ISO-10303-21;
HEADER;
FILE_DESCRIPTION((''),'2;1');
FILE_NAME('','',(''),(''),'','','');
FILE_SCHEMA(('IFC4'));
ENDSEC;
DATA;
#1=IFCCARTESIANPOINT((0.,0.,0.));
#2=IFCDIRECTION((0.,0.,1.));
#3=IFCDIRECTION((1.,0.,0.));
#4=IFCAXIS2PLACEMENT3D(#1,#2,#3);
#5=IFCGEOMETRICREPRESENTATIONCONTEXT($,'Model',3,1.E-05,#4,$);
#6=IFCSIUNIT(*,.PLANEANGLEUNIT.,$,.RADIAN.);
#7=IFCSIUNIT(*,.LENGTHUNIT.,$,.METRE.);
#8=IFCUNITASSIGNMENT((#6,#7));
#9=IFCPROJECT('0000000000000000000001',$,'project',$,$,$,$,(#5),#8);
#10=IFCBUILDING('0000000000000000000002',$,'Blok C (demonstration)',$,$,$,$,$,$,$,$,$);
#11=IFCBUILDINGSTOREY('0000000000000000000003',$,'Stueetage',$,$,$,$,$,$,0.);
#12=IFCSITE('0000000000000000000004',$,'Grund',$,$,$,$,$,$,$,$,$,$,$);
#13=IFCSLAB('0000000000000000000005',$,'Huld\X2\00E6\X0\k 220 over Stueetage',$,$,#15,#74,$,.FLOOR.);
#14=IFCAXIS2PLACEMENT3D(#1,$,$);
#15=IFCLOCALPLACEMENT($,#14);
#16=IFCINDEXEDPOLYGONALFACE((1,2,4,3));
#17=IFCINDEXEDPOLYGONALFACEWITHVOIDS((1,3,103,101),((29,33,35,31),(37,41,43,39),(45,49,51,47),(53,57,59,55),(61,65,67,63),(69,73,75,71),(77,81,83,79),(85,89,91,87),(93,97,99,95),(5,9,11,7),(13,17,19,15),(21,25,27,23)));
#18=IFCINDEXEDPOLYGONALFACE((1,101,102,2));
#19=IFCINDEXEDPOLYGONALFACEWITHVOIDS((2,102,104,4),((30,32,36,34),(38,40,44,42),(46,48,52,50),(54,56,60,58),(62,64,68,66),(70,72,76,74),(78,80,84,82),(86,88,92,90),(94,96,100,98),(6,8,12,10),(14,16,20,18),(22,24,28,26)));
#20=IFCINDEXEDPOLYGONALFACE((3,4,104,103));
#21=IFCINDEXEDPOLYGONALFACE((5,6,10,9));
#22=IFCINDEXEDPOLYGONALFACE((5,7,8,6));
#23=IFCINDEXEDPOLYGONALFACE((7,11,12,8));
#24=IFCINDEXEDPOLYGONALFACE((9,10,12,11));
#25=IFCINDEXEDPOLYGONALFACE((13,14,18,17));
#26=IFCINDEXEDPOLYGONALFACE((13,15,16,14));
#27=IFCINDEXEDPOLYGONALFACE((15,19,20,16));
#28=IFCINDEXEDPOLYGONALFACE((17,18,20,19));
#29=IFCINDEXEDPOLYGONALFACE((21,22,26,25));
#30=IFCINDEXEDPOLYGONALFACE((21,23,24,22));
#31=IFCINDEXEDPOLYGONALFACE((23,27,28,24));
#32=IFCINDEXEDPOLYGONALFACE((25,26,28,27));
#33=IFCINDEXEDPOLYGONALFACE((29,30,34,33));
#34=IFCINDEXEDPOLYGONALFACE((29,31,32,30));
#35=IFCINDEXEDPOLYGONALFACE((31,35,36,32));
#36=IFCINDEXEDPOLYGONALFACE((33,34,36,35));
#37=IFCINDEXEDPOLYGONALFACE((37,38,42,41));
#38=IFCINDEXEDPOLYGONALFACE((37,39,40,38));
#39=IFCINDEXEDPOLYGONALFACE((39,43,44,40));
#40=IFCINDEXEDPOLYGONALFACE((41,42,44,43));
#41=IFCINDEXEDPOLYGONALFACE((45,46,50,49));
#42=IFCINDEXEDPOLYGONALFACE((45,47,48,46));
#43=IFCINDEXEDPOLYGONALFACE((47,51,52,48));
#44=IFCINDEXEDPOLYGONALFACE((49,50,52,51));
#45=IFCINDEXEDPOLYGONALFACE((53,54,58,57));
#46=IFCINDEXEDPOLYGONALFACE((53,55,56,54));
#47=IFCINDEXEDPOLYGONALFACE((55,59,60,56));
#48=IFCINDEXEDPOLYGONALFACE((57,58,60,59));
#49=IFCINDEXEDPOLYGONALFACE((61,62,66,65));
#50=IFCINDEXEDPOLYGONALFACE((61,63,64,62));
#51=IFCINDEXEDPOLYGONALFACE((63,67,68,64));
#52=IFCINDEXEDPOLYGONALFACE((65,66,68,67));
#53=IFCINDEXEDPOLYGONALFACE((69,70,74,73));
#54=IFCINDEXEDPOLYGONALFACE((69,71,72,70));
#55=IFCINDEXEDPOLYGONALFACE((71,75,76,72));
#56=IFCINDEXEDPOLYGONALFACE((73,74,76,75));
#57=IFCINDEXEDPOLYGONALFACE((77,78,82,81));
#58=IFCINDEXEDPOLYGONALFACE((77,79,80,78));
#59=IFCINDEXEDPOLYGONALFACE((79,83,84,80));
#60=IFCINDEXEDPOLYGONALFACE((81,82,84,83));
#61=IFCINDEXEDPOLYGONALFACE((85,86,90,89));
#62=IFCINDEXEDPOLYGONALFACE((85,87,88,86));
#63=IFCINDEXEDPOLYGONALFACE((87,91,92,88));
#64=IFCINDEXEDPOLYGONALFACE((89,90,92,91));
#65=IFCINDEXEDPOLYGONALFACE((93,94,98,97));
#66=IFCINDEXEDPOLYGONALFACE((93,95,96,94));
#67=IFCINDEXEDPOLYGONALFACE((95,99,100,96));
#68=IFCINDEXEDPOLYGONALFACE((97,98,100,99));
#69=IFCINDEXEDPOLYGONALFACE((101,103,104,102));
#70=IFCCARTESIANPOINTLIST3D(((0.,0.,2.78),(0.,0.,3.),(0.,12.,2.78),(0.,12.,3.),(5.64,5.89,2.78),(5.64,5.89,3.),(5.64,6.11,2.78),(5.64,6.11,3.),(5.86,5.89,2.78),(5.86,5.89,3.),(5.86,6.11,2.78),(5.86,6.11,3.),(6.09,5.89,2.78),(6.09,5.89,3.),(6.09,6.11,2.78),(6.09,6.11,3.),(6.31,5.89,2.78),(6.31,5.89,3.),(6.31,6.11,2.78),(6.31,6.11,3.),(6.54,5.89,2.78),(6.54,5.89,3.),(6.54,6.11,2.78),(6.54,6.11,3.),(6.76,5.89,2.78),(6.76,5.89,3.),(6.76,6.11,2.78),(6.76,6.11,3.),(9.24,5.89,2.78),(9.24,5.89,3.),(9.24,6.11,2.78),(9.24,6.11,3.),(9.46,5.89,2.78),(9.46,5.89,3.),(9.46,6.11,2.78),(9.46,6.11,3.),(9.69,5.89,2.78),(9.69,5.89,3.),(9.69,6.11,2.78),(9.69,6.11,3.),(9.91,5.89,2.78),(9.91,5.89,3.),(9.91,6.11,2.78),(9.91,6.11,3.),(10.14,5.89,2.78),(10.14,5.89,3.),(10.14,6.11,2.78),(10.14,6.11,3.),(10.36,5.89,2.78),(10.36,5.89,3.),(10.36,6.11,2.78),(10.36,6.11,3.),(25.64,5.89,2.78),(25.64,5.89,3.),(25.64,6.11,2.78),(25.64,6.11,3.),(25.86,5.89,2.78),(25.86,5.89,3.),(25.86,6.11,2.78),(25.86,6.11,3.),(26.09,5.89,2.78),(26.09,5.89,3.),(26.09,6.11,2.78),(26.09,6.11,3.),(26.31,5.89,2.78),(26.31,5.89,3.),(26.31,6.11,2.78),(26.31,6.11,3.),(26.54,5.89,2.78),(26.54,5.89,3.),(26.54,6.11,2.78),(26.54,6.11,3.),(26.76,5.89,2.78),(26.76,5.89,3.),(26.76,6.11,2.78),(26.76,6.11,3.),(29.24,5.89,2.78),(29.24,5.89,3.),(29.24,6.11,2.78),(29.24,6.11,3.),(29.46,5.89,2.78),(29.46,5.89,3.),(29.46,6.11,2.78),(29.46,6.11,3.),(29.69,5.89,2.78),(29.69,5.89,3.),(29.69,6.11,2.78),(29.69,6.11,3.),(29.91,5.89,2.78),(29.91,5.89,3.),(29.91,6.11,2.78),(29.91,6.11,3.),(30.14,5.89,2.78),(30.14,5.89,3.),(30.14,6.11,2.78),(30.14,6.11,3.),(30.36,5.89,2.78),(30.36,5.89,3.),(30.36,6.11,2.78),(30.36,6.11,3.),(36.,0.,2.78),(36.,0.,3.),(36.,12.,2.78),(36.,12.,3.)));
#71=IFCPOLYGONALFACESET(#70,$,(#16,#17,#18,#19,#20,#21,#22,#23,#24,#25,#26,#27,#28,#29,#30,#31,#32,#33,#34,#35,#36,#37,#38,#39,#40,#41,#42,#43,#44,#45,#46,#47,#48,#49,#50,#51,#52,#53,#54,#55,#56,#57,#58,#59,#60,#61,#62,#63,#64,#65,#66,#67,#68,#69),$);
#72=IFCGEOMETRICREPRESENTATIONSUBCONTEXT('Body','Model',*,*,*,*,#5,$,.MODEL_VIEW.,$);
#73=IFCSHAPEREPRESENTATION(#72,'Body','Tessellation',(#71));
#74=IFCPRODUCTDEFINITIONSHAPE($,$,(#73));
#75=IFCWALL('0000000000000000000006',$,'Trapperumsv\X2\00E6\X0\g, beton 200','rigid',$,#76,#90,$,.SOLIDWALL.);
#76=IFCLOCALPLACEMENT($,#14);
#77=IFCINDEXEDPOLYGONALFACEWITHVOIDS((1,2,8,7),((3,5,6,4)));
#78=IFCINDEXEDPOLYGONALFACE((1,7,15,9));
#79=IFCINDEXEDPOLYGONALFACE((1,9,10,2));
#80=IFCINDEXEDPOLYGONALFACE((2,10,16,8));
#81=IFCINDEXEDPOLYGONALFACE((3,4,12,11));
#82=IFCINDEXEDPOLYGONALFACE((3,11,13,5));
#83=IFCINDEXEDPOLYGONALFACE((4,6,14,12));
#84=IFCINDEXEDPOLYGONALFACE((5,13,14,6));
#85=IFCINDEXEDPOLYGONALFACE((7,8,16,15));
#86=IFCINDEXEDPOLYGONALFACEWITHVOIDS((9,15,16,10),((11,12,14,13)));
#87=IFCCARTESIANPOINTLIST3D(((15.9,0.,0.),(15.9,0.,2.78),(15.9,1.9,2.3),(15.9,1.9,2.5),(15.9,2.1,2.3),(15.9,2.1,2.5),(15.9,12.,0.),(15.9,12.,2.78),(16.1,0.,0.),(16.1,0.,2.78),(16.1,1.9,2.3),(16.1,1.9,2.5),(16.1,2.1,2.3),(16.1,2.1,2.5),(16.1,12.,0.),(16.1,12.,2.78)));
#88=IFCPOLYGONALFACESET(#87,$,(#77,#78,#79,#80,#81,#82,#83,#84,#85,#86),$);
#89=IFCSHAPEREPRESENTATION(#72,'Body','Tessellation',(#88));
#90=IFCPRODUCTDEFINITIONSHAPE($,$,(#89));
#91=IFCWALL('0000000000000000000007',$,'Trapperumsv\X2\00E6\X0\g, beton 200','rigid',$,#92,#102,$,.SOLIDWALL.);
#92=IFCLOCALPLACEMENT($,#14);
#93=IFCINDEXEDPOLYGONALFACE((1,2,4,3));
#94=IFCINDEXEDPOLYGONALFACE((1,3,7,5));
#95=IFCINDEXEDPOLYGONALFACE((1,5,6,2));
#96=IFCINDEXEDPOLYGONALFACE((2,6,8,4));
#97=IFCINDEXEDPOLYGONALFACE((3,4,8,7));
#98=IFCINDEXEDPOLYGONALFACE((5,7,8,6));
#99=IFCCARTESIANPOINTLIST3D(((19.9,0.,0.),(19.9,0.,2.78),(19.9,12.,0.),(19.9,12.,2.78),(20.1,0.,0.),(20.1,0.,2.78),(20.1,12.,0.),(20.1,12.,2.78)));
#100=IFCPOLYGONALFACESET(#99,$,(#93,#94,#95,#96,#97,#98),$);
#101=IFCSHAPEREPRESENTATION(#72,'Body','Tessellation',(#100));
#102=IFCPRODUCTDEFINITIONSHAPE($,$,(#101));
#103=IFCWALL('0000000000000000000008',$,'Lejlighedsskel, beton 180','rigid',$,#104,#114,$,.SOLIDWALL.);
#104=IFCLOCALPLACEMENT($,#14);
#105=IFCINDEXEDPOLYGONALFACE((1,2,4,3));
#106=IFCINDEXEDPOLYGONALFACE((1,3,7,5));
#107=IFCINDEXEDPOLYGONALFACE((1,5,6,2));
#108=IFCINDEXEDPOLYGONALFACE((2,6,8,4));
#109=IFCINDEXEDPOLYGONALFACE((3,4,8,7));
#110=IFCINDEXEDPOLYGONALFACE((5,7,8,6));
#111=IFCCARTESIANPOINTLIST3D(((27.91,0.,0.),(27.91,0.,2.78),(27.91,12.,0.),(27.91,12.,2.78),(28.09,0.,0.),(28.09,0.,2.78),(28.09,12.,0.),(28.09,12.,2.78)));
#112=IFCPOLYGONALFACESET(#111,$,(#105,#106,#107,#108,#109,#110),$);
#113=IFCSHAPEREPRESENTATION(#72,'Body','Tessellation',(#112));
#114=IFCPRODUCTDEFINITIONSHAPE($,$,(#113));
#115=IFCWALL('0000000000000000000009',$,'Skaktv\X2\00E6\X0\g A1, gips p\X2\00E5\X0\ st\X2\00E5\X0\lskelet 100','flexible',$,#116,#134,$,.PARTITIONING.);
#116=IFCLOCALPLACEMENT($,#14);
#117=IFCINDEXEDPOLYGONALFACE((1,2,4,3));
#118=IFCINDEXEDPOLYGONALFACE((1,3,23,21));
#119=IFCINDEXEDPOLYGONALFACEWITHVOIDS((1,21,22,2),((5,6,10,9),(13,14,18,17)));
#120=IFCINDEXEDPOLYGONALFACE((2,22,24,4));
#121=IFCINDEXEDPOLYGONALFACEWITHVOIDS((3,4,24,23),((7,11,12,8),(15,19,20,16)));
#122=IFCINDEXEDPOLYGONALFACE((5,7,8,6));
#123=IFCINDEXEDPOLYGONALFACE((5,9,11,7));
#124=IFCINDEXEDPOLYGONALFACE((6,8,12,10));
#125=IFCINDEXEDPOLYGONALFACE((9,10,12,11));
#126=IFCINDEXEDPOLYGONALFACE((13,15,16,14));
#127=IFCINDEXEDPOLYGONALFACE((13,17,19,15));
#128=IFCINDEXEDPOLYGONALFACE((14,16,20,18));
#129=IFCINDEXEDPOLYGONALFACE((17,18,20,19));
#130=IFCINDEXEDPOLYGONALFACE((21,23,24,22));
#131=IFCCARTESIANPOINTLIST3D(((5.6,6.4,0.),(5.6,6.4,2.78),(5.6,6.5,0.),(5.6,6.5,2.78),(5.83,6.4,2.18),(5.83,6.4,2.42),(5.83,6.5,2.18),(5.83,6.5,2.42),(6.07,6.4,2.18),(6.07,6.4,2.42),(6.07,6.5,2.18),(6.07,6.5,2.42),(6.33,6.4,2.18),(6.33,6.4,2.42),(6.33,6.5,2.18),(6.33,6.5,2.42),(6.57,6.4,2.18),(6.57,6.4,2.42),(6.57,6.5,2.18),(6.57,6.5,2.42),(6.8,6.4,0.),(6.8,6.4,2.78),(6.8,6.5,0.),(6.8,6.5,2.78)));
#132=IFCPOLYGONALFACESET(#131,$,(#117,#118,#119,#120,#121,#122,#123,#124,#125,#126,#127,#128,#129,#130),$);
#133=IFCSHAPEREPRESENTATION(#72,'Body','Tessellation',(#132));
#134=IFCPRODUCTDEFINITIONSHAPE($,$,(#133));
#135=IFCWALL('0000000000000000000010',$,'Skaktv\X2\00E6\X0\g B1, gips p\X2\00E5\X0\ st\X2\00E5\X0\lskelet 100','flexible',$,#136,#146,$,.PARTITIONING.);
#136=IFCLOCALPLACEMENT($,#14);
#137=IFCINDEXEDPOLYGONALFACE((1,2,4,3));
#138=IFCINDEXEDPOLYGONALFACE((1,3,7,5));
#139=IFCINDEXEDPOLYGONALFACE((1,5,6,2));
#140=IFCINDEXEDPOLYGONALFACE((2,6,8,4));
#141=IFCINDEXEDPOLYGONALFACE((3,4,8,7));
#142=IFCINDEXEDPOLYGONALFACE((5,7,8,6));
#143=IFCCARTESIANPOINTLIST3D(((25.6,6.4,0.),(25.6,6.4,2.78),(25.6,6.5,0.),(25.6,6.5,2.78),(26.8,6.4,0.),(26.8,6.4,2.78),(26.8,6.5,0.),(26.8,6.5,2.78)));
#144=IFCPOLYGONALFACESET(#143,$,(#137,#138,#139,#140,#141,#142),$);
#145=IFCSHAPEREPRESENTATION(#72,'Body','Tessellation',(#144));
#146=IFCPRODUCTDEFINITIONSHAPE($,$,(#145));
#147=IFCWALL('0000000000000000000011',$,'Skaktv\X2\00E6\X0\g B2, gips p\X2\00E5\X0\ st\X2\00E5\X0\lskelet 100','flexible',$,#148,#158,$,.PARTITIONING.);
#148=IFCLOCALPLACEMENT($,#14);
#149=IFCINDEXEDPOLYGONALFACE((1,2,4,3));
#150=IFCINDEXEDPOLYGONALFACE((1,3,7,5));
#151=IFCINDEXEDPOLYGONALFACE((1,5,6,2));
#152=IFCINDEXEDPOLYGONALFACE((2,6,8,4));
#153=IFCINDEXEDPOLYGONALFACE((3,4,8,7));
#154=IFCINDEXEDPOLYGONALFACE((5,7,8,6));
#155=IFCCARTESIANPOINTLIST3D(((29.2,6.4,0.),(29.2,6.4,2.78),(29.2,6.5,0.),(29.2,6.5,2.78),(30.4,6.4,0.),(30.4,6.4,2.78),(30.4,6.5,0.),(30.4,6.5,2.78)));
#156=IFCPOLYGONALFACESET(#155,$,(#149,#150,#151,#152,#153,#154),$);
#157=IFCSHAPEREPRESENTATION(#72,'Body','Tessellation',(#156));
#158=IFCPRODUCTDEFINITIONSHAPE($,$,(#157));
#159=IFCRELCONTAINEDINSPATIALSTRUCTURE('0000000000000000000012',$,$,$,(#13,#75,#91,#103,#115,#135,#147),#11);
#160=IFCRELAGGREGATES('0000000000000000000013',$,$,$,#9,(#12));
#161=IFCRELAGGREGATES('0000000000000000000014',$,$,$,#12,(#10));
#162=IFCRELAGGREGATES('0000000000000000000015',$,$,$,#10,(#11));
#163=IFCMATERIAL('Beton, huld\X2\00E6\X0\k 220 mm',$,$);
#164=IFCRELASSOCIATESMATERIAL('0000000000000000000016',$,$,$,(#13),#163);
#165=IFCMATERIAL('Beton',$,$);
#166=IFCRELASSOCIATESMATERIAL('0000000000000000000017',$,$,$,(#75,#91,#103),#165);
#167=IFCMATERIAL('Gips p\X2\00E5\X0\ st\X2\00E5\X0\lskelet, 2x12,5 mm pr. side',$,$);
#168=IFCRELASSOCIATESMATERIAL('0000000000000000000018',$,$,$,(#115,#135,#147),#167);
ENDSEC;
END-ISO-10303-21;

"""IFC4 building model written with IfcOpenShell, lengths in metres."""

from ifc_helpers import new_model, si_unit, frame, origin, origin_with_axes, place, context, subcontext, project, spatial, polyline, outline, extrude, material, element, save


model = new_model("IFC4")

# Units and contexts
model_context = context("Model", 3, precision=1e-05, world=origin_with_axes())
body_context = subcontext(model_context, "Body", "Model", "MODEL_VIEW")
ifc_project = project(units=[si_unit("PLANEANGLEUNIT", "RADIAN"), si_unit("LENGTHUNIT", "METRE")], contexts=[model_context])

# Site, building, storey
site = spatial("IfcSite", under=ifc_project, Name="Grund")
building = spatial("IfcBuilding", under=site, Name="Blok C (demonstration)")
storey = spatial("IfcBuildingStorey", under=building, Name="Stueetage", Elevation=0.0)

# Slab, openings
ifc_material_1 = material(Name="Beton, huldæk 220 mm")
slab_placement = place(None, origin_with_axes())
slab = element("IfcSlab", 1, at=slab_placement, inside=storey, material=ifc_material_1, Name="Huldæk 220 over Stueetage", PredefinedType="FLOOR", context=body_context, shape_type="SweptSolid", body=[
    extrude(outline(polyline([(0.0, 0.0), (36.0, 0.0), (36.0, 12.0), (0.0, 12.0), (0.0, 0.0)])), frame((0.0, 0.0, 2.78)), (0.0, 0.0, 1.0), 0.22),
])
opening_1_placement = place(slab_placement, origin_with_axes())
element("IfcOpeningElement", 2, at=opening_1_placement, cuts=slab, PredefinedType="OPENING", context=body_context, shape_type="SweptSolid", body=[
    extrude(outline(polyline([(5.64, 5.89), (5.86, 5.89), (5.86, 6.11), (5.64, 6.11), (5.64, 5.89)])), frame((0.0, 0.0, 2.77)), (0.0, 0.0, 1.0), 0.24),
])
opening_2_placement = place(slab_placement, origin_with_axes())
element("IfcOpeningElement", 3, at=opening_2_placement, cuts=slab, PredefinedType="OPENING", context=body_context, shape_type="SweptSolid", body=[
    extrude(outline(polyline([(6.09, 5.89), (6.31, 5.89), (6.31, 6.11), (6.09, 6.11), (6.09, 5.89)])), frame((0.0, 0.0, 2.77)), (0.0, 0.0, 1.0), 0.24),
])
opening_3_placement = place(slab_placement, origin_with_axes())
element("IfcOpeningElement", 4, at=opening_3_placement, cuts=slab, PredefinedType="OPENING", context=body_context, shape_type="SweptSolid", body=[
    extrude(outline(polyline([(6.54, 5.89), (6.76, 5.89), (6.76, 6.11), (6.54, 6.11), (6.54, 5.89)])), frame((0.0, 0.0, 2.77)), (0.0, 0.0, 1.0), 0.24),
])
opening_4_placement = place(slab_placement, origin_with_axes())
element("IfcOpeningElement", 5, at=opening_4_placement, cuts=slab, PredefinedType="OPENING", context=body_context, shape_type="SweptSolid", body=[
    extrude(outline(polyline([(9.24, 5.89), (9.46, 5.89), (9.46, 6.11), (9.24, 6.11), (9.24, 5.89)])), frame((0.0, 0.0, 2.77)), (0.0, 0.0, 1.0), 0.24),
])
opening_5_placement = place(slab_placement, origin_with_axes())
element("IfcOpeningElement", 6, at=opening_5_placement, cuts=slab, PredefinedType="OPENING", context=body_context, shape_type="SweptSolid", body=[
    extrude(outline(polyline([(9.69, 5.89), (9.91, 5.89), (9.91, 6.11), (9.69, 6.11), (9.69, 5.89)])), frame((0.0, 0.0, 2.77)), (0.0, 0.0, 1.0), 0.24),
])
opening_6_placement = place(slab_placement, origin_with_axes())
element("IfcOpeningElement", 7, at=opening_6_placement, cuts=slab, PredefinedType="OPENING", context=body_context, shape_type="SweptSolid", body=[
    extrude(outline(polyline([(10.14, 5.89), (10.36, 5.89), (10.36, 6.11), (10.14, 6.11), (10.14, 5.89)])), frame((0.0, 0.0, 2.77)), (0.0, 0.0, 1.0), 0.24),
])
opening_7_placement = place(slab_placement, origin_with_axes())
element("IfcOpeningElement", 8, at=opening_7_placement, cuts=slab, PredefinedType="OPENING", context=body_context, shape_type="SweptSolid", body=[
    extrude(outline(polyline([(25.64, 5.89), (25.86, 5.89), (25.86, 6.11), (25.64, 6.11), (25.64, 5.89)])), frame((0.0, 0.0, 2.77)), (0.0, 0.0, 1.0), 0.24),
])
opening_8_placement = place(slab_placement, origin_with_axes())
element("IfcOpeningElement", 9, at=opening_8_placement, cuts=slab, PredefinedType="OPENING", context=body_context, shape_type="SweptSolid", body=[
    extrude(outline(polyline([(26.09, 5.89), (26.31, 5.89), (26.31, 6.11), (26.09, 6.11), (26.09, 5.89)])), frame((0.0, 0.0, 2.77)), (0.0, 0.0, 1.0), 0.24),
])
opening_9_placement = place(slab_placement, origin_with_axes())
element("IfcOpeningElement", 10, at=opening_9_placement, cuts=slab, PredefinedType="OPENING", context=body_context, shape_type="SweptSolid", body=[
    extrude(outline(polyline([(26.54, 5.89), (26.76, 5.89), (26.76, 6.11), (26.54, 6.11), (26.54, 5.89)])), frame((0.0, 0.0, 2.77)), (0.0, 0.0, 1.0), 0.24),
])
opening_10_placement = place(slab_placement, origin_with_axes())
element("IfcOpeningElement", 11, at=opening_10_placement, cuts=slab, PredefinedType="OPENING", context=body_context, shape_type="SweptSolid", body=[
    extrude(outline(polyline([(29.24, 5.89), (29.46, 5.89), (29.46, 6.11), (29.24, 6.11), (29.24, 5.89)])), frame((0.0, 0.0, 2.77)), (0.0, 0.0, 1.0), 0.24),
])
opening_11_placement = place(slab_placement, origin_with_axes())
element("IfcOpeningElement", 12, at=opening_11_placement, cuts=slab, PredefinedType="OPENING", context=body_context, shape_type="SweptSolid", body=[
    extrude(outline(polyline([(29.69, 5.89), (29.91, 5.89), (29.91, 6.11), (29.69, 6.11), (29.69, 5.89)])), frame((0.0, 0.0, 2.77)), (0.0, 0.0, 1.0), 0.24),
])
opening_12_placement = place(slab_placement, origin_with_axes())
element("IfcOpeningElement", 13, at=opening_12_placement, cuts=slab, PredefinedType="OPENING", context=body_context, shape_type="SweptSolid", body=[
    extrude(outline(polyline([(30.14, 5.89), (30.36, 5.89), (30.36, 6.11), (30.14, 6.11), (30.14, 5.89)])), frame((0.0, 0.0, 2.77)), (0.0, 0.0, 1.0), 0.24),
])

# Wall, opening
ifc_material_2 = material(Name="Beton")
wall_1_placement = place(None, origin_with_axes())
wall_1 = element("IfcWall", 14, at=wall_1_placement, inside=storey, material=ifc_material_2, Name="Trapperumsvæg, beton 200", Description="rigid", PredefinedType="SOLIDWALL", context=body_context, shape_type="SweptSolid", body=[
    extrude(outline(polyline([(15.9, 0.0), (16.1, 0.0), (16.1, 12.0), (15.9, 12.0), (15.9, 0.0)])), origin(), (0.0, 0.0, 1.0), 2.78),
])
opening_13_placement = place(wall_1_placement, origin_with_axes())
element("IfcOpeningElement", 15, at=opening_13_placement, cuts=wall_1, PredefinedType="OPENING", context=body_context, shape_type="SweptSolid", body=[
    extrude(outline(polyline([(15.88, 1.9), (16.12, 1.9), (16.12, 2.1), (15.88, 2.1), (15.88, 1.9)])), frame((0.0, 0.0, 2.3)), (0.0, 0.0, 1.0), 0.2),
])

# Wall
wall_2_placement = place(None, origin_with_axes())
element("IfcWall", 16, at=wall_2_placement, inside=storey, material=ifc_material_2, Name="Trapperumsvæg, beton 200", Description="rigid", PredefinedType="SOLIDWALL", context=body_context, shape_type="SweptSolid", body=[
    extrude(outline(polyline([(19.9, 0.0), (20.1, 0.0), (20.1, 12.0), (19.9, 12.0), (19.9, 0.0)])), origin(), (0.0, 0.0, 1.0), 2.78),
])

# Wall
wall_3_placement = place(None, origin_with_axes())
element("IfcWall", 17, at=wall_3_placement, inside=storey, material=ifc_material_2, Name="Lejlighedsskel, beton 180", Description="rigid", PredefinedType="SOLIDWALL", context=body_context, shape_type="SweptSolid", body=[
    extrude(outline(polyline([(27.91, 0.0), (28.09, 0.0), (28.09, 12.0), (27.91, 12.0), (27.91, 0.0)])), origin(), (0.0, 0.0, 1.0), 2.78),
])

# Wall, openings
ifc_material_3 = material(Name="Gips på stålskelet, 2x12,5 mm pr. side")
wall_4_placement = place(None, origin_with_axes())
wall_4 = element("IfcWall", 18, at=wall_4_placement, inside=storey, material=ifc_material_3, Name="Skaktvæg A1, gips på stålskelet 100", Description="flexible", PredefinedType="PARTITIONING", context=body_context, shape_type="SweptSolid", body=[
    extrude(outline(polyline([(5.6, 6.4), (6.8, 6.4), (6.8, 6.5), (5.6, 6.5), (5.6, 6.4)])), origin(), (0.0, 0.0, 1.0), 2.78),
])
opening_14_placement = place(wall_4_placement, origin_with_axes())
element("IfcOpeningElement", 19, at=opening_14_placement, cuts=wall_4, PredefinedType="OPENING", context=body_context, shape_type="SweptSolid", body=[
    extrude(outline(polyline([(5.83, 6.33), (6.07, 6.33), (6.07, 6.57), (5.83, 6.57), (5.83, 6.33)])), frame((0.0, 0.0, 2.18)), (0.0, 0.0, 1.0), 0.24),
])
opening_15_placement = place(wall_4_placement, origin_with_axes())
element("IfcOpeningElement", 20, at=opening_15_placement, cuts=wall_4, PredefinedType="OPENING", context=body_context, shape_type="SweptSolid", body=[
    extrude(outline(polyline([(6.33, 6.33), (6.57, 6.33), (6.57, 6.57), (6.33, 6.57), (6.33, 6.33)])), frame((0.0, 0.0, 2.18)), (0.0, 0.0, 1.0), 0.24),
])

# Walls
wall_5_placement = place(None, origin_with_axes())
element("IfcWall", 21, at=wall_5_placement, inside=storey, material=ifc_material_3, Name="Skaktvæg B1, gips på stålskelet 100", Description="flexible", PredefinedType="PARTITIONING", context=body_context, shape_type="SweptSolid", body=[
    extrude(outline(polyline([(25.6, 6.4), (26.8, 6.4), (26.8, 6.5), (25.6, 6.5), (25.6, 6.4)])), origin(), (0.0, 0.0, 1.0), 2.78),
])
wall_6_placement = place(None, origin_with_axes())
element("IfcWall", 22, at=wall_6_placement, inside=storey, material=ifc_material_3, Name="Skaktvæg B2, gips på stålskelet 100", Description="flexible", PredefinedType="PARTITIONING", context=body_context, shape_type="SweptSolid", body=[
    extrude(outline(polyline([(29.2, 6.4), (30.4, 6.4), (30.4, 6.5), (29.2, 6.5), (29.2, 6.4)])), origin(), (0.0, 0.0, 1.0), 2.78),
])

save(model, "model.ifc")
